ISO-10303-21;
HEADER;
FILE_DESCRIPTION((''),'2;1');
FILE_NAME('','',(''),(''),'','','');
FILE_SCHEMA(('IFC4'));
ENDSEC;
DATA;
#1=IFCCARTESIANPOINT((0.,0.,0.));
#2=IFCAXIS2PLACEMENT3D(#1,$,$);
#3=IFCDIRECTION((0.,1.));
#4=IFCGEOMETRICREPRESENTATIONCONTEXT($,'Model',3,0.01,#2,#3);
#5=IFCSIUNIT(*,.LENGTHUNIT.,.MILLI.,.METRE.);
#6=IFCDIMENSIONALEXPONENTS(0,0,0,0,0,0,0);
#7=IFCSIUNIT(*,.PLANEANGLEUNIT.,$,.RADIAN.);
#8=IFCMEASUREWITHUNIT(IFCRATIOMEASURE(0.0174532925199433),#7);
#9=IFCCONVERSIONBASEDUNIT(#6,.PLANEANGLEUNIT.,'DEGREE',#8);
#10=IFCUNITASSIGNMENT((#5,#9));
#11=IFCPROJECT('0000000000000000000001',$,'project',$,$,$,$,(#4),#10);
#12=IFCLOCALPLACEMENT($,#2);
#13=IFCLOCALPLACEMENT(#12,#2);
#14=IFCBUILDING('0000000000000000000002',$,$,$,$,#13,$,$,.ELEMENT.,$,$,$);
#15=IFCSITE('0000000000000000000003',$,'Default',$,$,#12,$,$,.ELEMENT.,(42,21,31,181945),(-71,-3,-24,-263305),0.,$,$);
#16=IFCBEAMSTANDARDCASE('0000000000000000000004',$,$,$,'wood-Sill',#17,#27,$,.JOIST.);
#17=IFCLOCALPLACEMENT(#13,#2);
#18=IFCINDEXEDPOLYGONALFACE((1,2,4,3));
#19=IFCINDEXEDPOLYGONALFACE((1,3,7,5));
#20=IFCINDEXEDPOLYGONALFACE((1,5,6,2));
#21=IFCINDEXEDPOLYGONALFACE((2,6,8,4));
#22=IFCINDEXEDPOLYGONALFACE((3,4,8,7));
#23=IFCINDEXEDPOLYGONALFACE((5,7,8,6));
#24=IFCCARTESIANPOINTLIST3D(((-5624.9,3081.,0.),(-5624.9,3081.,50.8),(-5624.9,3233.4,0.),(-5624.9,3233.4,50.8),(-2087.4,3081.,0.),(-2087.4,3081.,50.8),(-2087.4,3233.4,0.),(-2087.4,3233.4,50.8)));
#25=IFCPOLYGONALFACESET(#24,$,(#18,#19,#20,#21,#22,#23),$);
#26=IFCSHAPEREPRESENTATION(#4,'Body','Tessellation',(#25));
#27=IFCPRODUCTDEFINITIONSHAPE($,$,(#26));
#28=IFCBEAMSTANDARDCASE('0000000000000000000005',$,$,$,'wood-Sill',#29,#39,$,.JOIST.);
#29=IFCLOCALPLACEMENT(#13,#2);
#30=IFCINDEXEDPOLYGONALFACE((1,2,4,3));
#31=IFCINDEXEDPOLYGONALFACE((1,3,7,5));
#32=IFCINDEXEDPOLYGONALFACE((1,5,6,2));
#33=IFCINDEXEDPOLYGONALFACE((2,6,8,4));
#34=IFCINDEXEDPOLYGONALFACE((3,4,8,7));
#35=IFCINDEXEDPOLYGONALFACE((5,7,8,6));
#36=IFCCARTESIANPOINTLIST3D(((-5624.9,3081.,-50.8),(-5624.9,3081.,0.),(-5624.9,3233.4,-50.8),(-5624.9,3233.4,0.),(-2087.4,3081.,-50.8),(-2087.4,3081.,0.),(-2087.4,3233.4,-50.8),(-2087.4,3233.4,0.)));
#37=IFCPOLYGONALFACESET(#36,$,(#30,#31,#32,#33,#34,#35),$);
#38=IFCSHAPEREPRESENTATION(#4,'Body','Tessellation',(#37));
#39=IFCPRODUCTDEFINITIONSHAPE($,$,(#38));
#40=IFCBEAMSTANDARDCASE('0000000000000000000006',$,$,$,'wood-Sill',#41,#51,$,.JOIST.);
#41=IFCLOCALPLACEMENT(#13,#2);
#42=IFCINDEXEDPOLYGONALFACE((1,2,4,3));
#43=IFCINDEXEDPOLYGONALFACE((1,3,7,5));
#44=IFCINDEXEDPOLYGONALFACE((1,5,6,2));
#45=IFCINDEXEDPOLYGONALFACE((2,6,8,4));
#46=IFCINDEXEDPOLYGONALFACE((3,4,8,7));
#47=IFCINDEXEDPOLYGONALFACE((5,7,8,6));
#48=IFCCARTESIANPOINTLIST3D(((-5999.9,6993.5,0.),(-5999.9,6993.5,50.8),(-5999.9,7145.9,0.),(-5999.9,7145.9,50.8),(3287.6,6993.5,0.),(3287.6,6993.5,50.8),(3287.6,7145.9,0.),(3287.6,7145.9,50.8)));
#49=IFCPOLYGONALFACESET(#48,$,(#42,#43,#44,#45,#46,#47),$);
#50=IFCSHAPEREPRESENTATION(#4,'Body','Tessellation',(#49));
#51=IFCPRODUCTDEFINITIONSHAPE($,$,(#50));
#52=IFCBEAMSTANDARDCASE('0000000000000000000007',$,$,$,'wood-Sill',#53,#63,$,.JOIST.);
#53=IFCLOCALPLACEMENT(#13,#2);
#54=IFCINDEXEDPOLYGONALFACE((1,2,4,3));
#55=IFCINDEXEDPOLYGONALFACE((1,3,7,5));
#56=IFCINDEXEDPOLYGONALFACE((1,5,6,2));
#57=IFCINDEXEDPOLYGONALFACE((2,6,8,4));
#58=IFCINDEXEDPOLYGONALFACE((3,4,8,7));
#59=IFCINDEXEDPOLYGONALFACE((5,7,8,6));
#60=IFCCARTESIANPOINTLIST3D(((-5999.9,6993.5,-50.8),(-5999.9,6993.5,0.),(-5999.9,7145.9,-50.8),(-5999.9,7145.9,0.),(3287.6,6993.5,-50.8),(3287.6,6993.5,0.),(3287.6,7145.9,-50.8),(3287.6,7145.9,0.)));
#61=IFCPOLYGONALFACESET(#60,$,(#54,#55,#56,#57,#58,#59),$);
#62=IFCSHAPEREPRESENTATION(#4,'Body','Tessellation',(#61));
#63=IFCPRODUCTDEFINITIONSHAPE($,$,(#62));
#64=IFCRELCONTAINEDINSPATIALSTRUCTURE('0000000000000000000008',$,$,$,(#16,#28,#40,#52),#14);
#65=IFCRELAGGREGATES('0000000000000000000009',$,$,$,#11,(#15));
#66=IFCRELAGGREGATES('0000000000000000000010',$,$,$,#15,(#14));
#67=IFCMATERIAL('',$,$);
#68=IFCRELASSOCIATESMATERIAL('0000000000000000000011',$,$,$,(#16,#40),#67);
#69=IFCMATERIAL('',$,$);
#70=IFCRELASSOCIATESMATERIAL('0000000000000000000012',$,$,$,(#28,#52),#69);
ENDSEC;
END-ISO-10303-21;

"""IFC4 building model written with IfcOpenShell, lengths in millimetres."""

from ifc_helpers import new_model, entity, si_unit, converted_unit, direction, frame, origin, place, context, project, spatial, rectangle, extrude, material, element, save


model = new_model("IFC4")

# Units and contexts
model_context = context("Model", 3, precision=0.01, world=origin(), true_north=direction((0.0, 1.0)))
ifc_project = project(units=[si_unit("LENGTHUNIT", "METRE", prefix="MILLI"), converted_unit("PLANEANGLEUNIT", "DEGREE", entity("IfcRatioMeasure", 0.0174532925199433), si_unit("PLANEANGLEUNIT", "RADIAN"), dimensions=[0, 0, 0, 0, 0, 0, 0])], contexts=[model_context])

# Site, building
site_placement = place(None, origin())
site = spatial("IfcSite", under=ifc_project, at=site_placement, Name="Default", CompositionType="ELEMENT", RefLatitude=(42, 21, 31, 181945), RefLongitude=(-71, -3, -24, -263305), RefElevation=0.0)
building_placement = place(site_placement, origin())
building = spatial("IfcBuilding", under=site, at=building_placement, CompositionType="ELEMENT")

# Shared definitions
placement_1 = place(building_placement, origin())
placement_2 = place(placement_1, frame((-2087.4, 3157.2, 0.0), z_axis=(0.0, 0.0, 1.0), x_axis=(-1.0, 0.0, 0.0)))
placement_3 = place(placement_1, frame((-5999.9, 7069.7, 0.0)))

# Beams
ifc_material_1 = material(Name="")
beam_1_placement = place(placement_2, frame((1768.8, 0.0, 0.0), z_axis=(0.0, 0.0, 1.0), x_axis=(-1.0, 0.0, 0.0)))
element("IfcBeamStandardCase", 1, at=beam_1_placement, inside=building, material=ifc_material_1, ObjectType="wood-Sill", PredefinedType="JOIST", context=model_context, shape_type="SweptSolid", body=[
    extrude(rectangle(XDim=3537.5, YDim=152.4), origin(), (0.0, 0.0, 1.0), 50.8),
])
ifc_material_2 = material(Name="")
beam_2_placement = place(placement_2, frame((1768.8, 0.0, -50.8), z_axis=(0.0, 0.0, 1.0), x_axis=(-1.0, 0.0, 0.0)))
element("IfcBeamStandardCase", 2, at=beam_2_placement, inside=building, material=ifc_material_2, ObjectType="wood-Sill", PredefinedType="JOIST", context=model_context, shape_type="SweptSolid", body=[
    extrude(rectangle(XDim=3537.5, YDim=152.4), origin(), (0.0, 0.0, 1.0), 50.8),
])
beam_3_placement = place(placement_3, frame((4643.8, 0.0, 0.0)))
element("IfcBeamStandardCase", 3, at=beam_3_placement, inside=building, material=ifc_material_1, ObjectType="wood-Sill", PredefinedType="JOIST", context=model_context, shape_type="SweptSolid", body=[
    extrude(rectangle(XDim=9287.5, YDim=152.4), origin(), (0.0, 0.0, 1.0), 50.8),
])
beam_4_placement = place(placement_3, frame((4643.8, 0.0, -50.8)))
element("IfcBeamStandardCase", 4, at=beam_4_placement, inside=building, material=ifc_material_2, ObjectType="wood-Sill", PredefinedType="JOIST", context=model_context, shape_type="SweptSolid", body=[
    extrude(rectangle(XDim=9287.5, YDim=152.4), origin(), (0.0, 0.0, 1.0), 50.8),
])

save(model, "model.ifc")
